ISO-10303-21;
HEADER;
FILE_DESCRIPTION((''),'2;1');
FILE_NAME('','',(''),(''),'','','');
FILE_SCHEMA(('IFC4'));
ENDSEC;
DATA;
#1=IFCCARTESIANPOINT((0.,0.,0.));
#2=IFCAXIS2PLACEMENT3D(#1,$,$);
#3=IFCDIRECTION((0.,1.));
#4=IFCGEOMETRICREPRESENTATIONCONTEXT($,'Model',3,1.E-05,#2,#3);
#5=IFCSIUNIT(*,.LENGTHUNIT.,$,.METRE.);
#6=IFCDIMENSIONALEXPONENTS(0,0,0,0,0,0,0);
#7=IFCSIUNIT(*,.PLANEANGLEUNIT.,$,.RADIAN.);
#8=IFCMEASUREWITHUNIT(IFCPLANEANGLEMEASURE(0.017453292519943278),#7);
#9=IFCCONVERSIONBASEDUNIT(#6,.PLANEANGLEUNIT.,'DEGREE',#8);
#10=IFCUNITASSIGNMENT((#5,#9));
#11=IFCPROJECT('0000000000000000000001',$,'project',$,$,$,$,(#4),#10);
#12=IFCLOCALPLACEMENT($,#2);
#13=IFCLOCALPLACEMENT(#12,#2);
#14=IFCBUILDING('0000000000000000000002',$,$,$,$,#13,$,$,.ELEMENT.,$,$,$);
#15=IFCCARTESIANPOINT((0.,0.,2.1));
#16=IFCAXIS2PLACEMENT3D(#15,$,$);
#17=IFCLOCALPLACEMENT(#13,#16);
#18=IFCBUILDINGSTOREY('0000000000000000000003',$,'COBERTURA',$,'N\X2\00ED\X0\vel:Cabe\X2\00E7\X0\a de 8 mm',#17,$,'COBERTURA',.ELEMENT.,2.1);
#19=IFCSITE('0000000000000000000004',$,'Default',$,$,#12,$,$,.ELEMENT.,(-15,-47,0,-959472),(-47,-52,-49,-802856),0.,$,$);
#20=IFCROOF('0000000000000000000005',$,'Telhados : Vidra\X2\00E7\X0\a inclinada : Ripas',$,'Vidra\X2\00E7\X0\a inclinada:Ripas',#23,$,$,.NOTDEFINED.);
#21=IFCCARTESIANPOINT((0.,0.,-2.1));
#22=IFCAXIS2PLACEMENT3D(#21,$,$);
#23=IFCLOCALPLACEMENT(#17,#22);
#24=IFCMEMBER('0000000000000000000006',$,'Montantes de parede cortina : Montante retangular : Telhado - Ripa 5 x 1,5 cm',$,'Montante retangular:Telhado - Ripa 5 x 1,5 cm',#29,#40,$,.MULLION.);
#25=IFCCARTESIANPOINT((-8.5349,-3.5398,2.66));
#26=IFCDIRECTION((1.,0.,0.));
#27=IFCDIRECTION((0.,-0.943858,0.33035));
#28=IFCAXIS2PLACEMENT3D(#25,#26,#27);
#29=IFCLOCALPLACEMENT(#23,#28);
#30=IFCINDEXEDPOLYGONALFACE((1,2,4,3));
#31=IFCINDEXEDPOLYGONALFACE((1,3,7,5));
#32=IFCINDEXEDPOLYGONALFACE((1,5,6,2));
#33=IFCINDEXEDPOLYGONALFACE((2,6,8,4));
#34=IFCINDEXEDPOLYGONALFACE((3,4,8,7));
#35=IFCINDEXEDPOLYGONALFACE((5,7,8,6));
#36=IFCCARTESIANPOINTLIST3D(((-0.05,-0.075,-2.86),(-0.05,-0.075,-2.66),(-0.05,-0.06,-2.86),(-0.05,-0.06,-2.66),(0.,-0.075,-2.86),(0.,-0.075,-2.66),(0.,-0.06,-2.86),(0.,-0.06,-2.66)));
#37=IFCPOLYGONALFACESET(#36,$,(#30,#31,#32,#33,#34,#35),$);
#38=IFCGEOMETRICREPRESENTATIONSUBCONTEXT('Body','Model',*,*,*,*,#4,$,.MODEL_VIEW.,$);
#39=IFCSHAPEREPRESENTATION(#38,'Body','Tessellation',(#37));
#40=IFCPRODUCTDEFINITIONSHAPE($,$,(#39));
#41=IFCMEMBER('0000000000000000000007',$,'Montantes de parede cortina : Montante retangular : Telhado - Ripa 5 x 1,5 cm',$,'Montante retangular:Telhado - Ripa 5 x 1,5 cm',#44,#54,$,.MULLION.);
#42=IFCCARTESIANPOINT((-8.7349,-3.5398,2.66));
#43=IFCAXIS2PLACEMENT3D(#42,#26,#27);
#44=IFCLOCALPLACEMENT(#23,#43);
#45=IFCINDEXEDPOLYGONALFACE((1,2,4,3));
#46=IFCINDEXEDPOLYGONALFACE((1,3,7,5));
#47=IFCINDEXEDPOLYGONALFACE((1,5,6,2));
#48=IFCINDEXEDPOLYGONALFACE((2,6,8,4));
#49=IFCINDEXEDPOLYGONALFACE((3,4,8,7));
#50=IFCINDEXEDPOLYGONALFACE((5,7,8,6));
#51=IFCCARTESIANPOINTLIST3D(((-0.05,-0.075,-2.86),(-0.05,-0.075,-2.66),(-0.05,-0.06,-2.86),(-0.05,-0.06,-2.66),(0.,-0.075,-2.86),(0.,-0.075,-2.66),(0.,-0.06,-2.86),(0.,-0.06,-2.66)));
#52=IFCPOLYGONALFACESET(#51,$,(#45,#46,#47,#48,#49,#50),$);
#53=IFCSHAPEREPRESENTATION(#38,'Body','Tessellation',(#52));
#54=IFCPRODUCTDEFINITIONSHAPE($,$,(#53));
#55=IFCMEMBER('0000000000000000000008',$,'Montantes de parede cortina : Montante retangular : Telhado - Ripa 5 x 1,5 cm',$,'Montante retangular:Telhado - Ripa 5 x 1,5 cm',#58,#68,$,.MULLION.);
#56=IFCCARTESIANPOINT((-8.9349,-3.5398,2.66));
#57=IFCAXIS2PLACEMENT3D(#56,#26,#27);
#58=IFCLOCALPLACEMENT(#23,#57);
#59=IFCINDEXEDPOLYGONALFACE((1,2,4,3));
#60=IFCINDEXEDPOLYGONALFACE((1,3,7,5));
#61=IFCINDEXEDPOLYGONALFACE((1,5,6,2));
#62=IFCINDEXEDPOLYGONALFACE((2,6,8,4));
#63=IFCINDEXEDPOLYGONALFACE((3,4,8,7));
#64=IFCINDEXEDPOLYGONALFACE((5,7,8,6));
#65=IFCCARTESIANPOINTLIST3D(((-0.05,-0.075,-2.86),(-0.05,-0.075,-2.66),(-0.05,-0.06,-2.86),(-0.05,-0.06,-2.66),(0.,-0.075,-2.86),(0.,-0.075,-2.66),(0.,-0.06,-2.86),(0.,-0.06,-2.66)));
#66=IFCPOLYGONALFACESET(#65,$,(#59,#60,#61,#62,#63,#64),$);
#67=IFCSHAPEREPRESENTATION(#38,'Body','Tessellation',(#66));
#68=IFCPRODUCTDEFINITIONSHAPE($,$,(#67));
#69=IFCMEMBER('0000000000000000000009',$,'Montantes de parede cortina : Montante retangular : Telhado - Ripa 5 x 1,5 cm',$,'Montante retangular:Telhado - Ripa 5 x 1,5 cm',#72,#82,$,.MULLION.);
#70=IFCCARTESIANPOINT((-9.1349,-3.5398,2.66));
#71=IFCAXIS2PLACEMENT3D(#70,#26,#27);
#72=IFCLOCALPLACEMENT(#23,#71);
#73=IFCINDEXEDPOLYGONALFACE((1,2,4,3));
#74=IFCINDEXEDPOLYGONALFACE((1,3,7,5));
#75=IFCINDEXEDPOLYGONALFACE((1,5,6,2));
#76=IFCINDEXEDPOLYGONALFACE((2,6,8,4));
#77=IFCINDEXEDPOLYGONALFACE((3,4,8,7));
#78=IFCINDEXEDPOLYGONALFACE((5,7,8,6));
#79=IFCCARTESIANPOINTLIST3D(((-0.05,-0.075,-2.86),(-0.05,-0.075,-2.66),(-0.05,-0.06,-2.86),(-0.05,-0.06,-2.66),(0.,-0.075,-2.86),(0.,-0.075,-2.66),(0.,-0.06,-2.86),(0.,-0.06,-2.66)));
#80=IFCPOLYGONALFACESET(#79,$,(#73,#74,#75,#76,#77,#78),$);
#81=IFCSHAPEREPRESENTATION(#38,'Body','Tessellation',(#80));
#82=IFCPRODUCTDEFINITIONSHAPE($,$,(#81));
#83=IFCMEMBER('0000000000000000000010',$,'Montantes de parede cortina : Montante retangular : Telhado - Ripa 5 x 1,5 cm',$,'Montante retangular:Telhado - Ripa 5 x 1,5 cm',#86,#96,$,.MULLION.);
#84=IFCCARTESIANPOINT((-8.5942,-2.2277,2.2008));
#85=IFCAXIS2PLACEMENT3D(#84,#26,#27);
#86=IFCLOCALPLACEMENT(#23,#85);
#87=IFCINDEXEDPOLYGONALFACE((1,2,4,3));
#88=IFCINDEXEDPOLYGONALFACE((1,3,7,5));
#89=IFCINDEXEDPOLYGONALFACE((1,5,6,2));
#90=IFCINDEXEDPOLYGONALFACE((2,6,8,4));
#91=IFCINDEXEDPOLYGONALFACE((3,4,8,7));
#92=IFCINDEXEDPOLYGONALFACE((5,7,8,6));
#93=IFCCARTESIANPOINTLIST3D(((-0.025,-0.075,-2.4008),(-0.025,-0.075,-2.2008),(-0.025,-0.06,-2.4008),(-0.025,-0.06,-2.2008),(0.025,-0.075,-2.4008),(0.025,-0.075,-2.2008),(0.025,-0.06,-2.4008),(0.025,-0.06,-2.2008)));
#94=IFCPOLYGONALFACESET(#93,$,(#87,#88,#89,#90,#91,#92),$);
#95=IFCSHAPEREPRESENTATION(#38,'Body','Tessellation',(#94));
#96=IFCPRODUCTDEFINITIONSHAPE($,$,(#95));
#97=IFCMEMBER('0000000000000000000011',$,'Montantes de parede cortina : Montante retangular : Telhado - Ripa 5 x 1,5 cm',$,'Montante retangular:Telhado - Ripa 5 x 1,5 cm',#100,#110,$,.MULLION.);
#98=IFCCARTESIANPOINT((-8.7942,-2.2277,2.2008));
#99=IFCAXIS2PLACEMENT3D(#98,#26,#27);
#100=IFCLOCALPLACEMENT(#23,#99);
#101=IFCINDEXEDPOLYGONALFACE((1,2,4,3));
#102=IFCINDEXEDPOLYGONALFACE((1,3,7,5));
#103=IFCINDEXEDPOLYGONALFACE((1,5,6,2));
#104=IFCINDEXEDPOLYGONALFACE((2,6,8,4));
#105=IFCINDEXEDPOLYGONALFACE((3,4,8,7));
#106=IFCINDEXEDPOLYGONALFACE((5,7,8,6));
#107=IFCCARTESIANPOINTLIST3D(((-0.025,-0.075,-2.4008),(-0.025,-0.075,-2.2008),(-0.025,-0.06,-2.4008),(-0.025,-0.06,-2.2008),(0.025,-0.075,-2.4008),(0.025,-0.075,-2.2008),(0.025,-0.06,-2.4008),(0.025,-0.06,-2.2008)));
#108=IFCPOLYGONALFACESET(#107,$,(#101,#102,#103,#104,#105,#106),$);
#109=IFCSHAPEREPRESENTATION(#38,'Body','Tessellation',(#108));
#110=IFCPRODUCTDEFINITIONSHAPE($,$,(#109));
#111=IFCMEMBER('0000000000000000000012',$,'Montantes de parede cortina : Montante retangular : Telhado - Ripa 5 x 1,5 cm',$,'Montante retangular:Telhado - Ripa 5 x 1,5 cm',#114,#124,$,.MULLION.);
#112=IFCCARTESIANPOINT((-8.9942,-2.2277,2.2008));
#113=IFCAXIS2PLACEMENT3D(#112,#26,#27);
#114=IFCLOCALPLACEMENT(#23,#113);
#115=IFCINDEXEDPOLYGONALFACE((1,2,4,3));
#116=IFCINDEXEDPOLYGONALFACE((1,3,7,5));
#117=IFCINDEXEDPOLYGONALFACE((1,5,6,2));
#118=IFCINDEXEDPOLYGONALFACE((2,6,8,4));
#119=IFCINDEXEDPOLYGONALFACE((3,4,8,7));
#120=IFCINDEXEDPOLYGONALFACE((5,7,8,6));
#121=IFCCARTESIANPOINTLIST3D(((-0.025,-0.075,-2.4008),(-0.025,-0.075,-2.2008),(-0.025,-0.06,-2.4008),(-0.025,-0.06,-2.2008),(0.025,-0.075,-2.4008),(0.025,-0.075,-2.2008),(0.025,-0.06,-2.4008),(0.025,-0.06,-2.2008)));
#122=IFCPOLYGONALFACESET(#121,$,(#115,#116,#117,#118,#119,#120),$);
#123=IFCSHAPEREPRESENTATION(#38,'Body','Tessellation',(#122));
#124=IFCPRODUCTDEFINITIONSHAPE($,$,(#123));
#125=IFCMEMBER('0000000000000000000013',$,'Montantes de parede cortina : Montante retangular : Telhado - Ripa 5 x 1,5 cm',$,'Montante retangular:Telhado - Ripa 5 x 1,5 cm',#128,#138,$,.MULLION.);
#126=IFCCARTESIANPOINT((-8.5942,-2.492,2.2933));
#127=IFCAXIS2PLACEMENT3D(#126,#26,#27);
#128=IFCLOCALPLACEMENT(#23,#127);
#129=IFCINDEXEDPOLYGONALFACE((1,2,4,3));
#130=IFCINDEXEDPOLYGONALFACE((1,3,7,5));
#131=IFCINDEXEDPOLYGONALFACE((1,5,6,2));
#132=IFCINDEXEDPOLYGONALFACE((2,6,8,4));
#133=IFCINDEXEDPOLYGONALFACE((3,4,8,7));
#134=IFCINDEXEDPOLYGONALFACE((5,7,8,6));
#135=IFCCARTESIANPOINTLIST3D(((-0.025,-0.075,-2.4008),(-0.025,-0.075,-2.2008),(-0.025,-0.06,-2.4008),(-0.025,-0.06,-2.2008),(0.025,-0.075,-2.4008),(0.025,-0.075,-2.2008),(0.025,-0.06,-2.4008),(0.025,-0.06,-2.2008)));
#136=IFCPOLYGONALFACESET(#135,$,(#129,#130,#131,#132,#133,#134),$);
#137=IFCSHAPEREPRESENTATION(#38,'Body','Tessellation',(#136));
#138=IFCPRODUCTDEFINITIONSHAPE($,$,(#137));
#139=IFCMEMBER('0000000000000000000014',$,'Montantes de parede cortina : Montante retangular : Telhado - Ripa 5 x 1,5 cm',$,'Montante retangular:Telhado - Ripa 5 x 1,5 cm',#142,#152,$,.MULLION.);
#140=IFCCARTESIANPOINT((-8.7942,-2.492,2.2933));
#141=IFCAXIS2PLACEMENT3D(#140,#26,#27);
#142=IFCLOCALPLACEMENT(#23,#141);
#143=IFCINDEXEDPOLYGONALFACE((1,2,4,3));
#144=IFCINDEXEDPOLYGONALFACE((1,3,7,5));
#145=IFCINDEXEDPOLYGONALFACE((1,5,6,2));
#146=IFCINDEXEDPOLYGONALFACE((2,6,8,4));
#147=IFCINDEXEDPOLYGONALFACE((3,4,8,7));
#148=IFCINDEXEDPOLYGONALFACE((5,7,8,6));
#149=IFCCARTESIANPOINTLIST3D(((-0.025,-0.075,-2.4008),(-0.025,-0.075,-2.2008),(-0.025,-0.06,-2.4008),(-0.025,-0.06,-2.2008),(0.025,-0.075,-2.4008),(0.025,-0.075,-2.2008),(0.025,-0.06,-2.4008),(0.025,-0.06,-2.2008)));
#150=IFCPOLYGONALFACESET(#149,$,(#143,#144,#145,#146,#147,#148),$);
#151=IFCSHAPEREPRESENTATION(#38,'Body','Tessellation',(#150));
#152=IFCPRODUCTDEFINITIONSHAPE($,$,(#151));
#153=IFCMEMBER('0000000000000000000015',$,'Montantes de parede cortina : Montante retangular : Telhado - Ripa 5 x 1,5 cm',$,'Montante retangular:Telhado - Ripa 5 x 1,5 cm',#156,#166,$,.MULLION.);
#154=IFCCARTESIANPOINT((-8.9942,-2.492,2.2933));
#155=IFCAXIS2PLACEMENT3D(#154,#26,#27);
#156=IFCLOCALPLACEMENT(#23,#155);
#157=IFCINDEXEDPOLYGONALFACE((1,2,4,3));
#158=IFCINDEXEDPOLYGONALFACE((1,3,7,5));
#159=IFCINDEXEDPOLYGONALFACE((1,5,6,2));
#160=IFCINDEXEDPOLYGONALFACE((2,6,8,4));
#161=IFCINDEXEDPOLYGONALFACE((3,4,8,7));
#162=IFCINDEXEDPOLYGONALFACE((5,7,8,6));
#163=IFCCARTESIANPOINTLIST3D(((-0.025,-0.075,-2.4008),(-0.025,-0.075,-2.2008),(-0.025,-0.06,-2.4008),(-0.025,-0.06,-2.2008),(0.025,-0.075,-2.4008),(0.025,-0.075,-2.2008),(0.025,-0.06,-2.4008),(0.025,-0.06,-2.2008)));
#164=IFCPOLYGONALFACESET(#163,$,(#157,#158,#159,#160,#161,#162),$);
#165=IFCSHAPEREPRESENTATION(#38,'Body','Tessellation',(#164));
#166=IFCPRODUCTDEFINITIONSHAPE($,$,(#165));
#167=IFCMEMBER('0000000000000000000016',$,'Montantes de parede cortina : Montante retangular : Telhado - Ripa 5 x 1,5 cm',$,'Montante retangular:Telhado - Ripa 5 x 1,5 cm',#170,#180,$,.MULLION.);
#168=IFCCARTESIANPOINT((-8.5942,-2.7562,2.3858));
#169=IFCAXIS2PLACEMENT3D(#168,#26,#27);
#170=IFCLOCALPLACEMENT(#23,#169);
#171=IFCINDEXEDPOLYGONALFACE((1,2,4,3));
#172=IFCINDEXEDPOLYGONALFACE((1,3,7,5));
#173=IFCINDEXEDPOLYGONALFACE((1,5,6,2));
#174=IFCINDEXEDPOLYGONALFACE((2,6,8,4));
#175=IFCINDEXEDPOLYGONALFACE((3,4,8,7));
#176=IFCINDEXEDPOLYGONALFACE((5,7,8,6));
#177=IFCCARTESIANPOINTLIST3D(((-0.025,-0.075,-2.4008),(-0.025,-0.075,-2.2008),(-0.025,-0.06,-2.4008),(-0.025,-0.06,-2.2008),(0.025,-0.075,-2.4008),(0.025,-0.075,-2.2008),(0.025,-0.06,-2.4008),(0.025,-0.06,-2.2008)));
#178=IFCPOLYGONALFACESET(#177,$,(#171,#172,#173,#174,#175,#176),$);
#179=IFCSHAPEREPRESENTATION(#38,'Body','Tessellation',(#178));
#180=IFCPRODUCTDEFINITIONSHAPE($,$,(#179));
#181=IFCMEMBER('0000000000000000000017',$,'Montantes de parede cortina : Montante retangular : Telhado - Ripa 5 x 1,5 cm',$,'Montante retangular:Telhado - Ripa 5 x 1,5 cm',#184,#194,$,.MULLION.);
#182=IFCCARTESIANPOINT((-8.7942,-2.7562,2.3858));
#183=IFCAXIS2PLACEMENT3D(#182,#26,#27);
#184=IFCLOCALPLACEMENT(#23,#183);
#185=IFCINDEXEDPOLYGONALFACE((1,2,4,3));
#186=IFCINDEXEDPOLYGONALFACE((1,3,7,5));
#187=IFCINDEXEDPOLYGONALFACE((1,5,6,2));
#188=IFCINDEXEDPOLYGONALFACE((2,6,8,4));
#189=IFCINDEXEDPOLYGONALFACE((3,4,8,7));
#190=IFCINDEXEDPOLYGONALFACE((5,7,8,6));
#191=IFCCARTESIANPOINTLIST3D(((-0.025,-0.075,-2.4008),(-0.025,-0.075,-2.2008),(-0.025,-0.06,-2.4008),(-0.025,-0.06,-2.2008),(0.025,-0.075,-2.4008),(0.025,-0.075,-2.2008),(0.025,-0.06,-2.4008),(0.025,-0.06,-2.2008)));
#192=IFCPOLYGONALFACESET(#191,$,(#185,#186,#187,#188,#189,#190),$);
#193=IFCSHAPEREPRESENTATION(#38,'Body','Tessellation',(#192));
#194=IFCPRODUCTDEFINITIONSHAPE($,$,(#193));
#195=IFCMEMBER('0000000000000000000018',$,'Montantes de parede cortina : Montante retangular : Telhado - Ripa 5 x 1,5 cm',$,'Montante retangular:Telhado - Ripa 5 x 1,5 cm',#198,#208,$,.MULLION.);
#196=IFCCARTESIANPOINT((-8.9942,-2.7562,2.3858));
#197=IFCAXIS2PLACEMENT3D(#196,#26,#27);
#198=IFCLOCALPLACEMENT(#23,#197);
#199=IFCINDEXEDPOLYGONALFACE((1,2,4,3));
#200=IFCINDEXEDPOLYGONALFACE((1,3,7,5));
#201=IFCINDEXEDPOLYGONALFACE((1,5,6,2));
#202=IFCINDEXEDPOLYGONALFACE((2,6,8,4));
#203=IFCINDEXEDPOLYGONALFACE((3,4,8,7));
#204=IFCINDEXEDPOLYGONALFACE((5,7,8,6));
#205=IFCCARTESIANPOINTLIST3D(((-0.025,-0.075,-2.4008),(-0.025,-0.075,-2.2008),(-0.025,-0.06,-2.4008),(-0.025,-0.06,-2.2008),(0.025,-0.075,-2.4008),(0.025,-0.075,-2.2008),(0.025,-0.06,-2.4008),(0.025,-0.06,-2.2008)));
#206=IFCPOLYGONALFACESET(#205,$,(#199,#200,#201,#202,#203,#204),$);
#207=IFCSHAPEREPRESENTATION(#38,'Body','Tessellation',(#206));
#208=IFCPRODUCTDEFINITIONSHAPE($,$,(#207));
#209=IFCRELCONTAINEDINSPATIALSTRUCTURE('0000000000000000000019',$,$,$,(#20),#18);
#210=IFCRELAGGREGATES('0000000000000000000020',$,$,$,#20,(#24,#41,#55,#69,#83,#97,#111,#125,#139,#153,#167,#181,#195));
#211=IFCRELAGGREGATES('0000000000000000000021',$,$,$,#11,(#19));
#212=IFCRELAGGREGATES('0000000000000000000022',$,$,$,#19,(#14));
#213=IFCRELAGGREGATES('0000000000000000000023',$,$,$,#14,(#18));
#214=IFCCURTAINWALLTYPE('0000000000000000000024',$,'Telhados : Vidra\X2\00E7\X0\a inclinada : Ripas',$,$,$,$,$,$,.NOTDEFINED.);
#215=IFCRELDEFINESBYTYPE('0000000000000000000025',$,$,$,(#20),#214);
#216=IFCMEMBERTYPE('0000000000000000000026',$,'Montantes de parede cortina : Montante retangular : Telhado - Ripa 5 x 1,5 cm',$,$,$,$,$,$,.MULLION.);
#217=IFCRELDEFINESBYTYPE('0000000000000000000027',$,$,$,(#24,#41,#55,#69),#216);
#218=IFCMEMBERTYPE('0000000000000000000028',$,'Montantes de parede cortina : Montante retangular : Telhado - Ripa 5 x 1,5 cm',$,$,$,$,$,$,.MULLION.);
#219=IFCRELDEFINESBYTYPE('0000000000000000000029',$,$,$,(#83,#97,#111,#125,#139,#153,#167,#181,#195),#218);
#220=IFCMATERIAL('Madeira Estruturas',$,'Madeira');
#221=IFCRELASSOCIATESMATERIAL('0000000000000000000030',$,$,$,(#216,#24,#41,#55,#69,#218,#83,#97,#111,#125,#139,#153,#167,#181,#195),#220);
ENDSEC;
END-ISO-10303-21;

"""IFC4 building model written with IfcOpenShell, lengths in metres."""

from ifc_helpers import new_model, entity, si_unit, converted_unit, direction, frame, origin, place, context, subcontext, project, spatial, indexed_curve, outline, extrude, source, transform, mapped, material, type_object, type_shapes, element, aggregate, save


model = new_model("IFC4")

# Units and contexts
model_context = context("Model", 3, precision=1e-05, world=origin(), true_north=direction((0.0, 1.0)))
body_context = subcontext(model_context, "Body", "Model", "MODEL_VIEW")
ifc_project = project(units=[si_unit("LENGTHUNIT", "METRE"), converted_unit("PLANEANGLEUNIT", "DEGREE", entity("IfcPlaneAngleMeasure", 0.017453292519943278), si_unit("PLANEANGLEUNIT", "RADIAN"), dimensions=[0, 0, 0, 0, 0, 0, 0])], contexts=[model_context])

# Site, building, storey
site_placement = place(None, origin())
site = spatial("IfcSite", under=ifc_project, at=site_placement, Name="Default", CompositionType="ELEMENT", RefLatitude=(-15, -47, 0, -959472), RefLongitude=(-47, -52, -49, -802856), RefElevation=0.0)
building_placement = place(site_placement, origin())
building = spatial("IfcBuilding", under=site, at=building_placement, CompositionType="ELEMENT")
storey_placement = place(building_placement, frame((0.0, 0.0, 2.1)))
storey = spatial("IfcBuildingStorey", under=building, at=storey_placement, Name="COBERTURA", ObjectType="Nível:Cabeça de 8 mm", LongName="COBERTURA", CompositionType="ELEMENT", Elevation=2.1)

# Roof, members
curtain_wall_type = type_object("IfcCurtainWallType", Name="Telhados : Vidraça inclinada : Ripas", PredefinedType="NOTDEFINED")
roof_placement = place(storey_placement, frame((0.0, 0.0, -2.1)))
roof = element("IfcRoof", 1, at=roof_placement, inside=storey, type_object=curtain_wall_type, Name="Telhados : Vidraça inclinada : Ripas", ObjectType="Vidraça inclinada:Ripas", PredefinedType="NOTDEFINED")
ifc_material = material(Name="Madeira Estruturas", Category="Madeira")
member_type_1 = type_object("IfcMemberType", Name="Montantes de parede cortina : Montante retangular : Telhado - Ripa 5 x 1,5 cm", PredefinedType="MULLION", material=ifc_material)
shared_shape_1 = source(origin(), body_context, "Body", "SweptSolid", [
    extrude(outline(indexed_curve([(-0.025, -0.0075), (0.025, -0.0075), (0.025, 0.0075), (-0.025, 0.0075), (-0.025, -0.0075)], self_intersect=False)), frame((-0.025, -0.0675, -2.86), z_axis=(0.0, 0.0, 1.0), x_axis=(-1.0, 0.0, 0.0)), (0.0, 0.0, 1.0), 0.2),
])
type_shapes(member_type_1, [shared_shape_1])
member_1_placement = place(roof_placement, frame((-8.5349, -3.5398, 2.66), z_axis=(1.0, 0.0, 0.0), x_axis=(0.0, -0.943858, 0.33035)))
member_1 = element("IfcMember", 2, at=member_1_placement, type_object=member_type_1, material=ifc_material, Name="Montantes de parede cortina : Montante retangular : Telhado - Ripa 5 x 1,5 cm", ObjectType="Montante retangular:Telhado - Ripa 5 x 1,5 cm", PredefinedType="MULLION", context=body_context, shape_type="MappedRepresentation", body=[
    mapped(shared_shape_1, transform((0.0, 0.0, 0.0), scale=1.0)),
])
member_2_placement = place(roof_placement, frame((-8.7349, -3.5398, 2.66), z_axis=(1.0, 0.0, 0.0), x_axis=(0.0, -0.943858, 0.33035)))
member_2 = element("IfcMember", 3, at=member_2_placement, type_object=member_type_1, material=ifc_material, Name="Montantes de parede cortina : Montante retangular : Telhado - Ripa 5 x 1,5 cm", ObjectType="Montante retangular:Telhado - Ripa 5 x 1,5 cm", PredefinedType="MULLION", context=body_context, shape_type="MappedRepresentation", body=[
    mapped(shared_shape_1, transform((0.0, 0.0, 0.0), scale=1.0)),
])
member_3_placement = place(roof_placement, frame((-8.9349, -3.5398, 2.66), z_axis=(1.0, 0.0, 0.0), x_axis=(0.0, -0.943858, 0.33035)))
member_3 = element("IfcMember", 4, at=member_3_placement, type_object=member_type_1, material=ifc_material, Name="Montantes de parede cortina : Montante retangular : Telhado - Ripa 5 x 1,5 cm", ObjectType="Montante retangular:Telhado - Ripa 5 x 1,5 cm", PredefinedType="MULLION", context=body_context, shape_type="MappedRepresentation", body=[
    mapped(shared_shape_1, transform((0.0, 0.0, 0.0), scale=1.0)),
])
member_4_placement = place(roof_placement, frame((-9.1349, -3.5398, 2.66), z_axis=(1.0, 0.0, 0.0), x_axis=(0.0, -0.943858, 0.33035)))
member_4 = element("IfcMember", 5, at=member_4_placement, type_object=member_type_1, material=ifc_material, Name="Montantes de parede cortina : Montante retangular : Telhado - Ripa 5 x 1,5 cm", ObjectType="Montante retangular:Telhado - Ripa 5 x 1,5 cm", PredefinedType="MULLION", context=body_context, shape_type="MappedRepresentation", body=[
    mapped(shared_shape_1, transform((0.0, 0.0, 0.0), scale=1.0)),
])
member_type_2 = type_object("IfcMemberType", Name="Montantes de parede cortina : Montante retangular : Telhado - Ripa 5 x 1,5 cm", PredefinedType="MULLION", material=ifc_material)
shared_shape_2 = source(origin(), body_context, "Body", "SweptSolid", [
    extrude(outline(indexed_curve([(-0.025, -0.0075), (0.025, -0.0075), (0.025, 0.0075), (-0.025, 0.0075), (-0.025, -0.0075)], self_intersect=False)), frame((0.0, -0.0675, -2.4008), z_axis=(0.0, 0.0, 1.0), x_axis=(-1.0, 0.0, 0.0)), (0.0, 0.0, 1.0), 0.2),
])
type_shapes(member_type_2, [shared_shape_2])
member_5_placement = place(roof_placement, frame((-8.5942, -2.2277, 2.2008), z_axis=(1.0, 0.0, 0.0), x_axis=(0.0, -0.943858, 0.33035)))
member_5 = element("IfcMember", 6, at=member_5_placement, type_object=member_type_2, material=ifc_material, Name="Montantes de parede cortina : Montante retangular : Telhado - Ripa 5 x 1,5 cm", ObjectType="Montante retangular:Telhado - Ripa 5 x 1,5 cm", PredefinedType="MULLION", context=body_context, shape_type="MappedRepresentation", body=[
    mapped(shared_shape_2, transform((0.0, 0.0, 0.0), scale=1.0)),
])
member_6_placement = place(roof_placement, frame((-8.7942, -2.2277, 2.2008), z_axis=(1.0, 0.0, 0.0), x_axis=(0.0, -0.943858, 0.33035)))
member_6 = element("IfcMember", 7, at=member_6_placement, type_object=member_type_2, material=ifc_material, Name="Montantes de parede cortina : Montante retangular : Telhado - Ripa 5 x 1,5 cm", ObjectType="Montante retangular:Telhado - Ripa 5 x 1,5 cm", PredefinedType="MULLION", context=body_context, shape_type="MappedRepresentation", body=[
    mapped(shared_shape_2, transform((0.0, 0.0, 0.0), scale=1.0)),
])
member_7_placement = place(roof_placement, frame((-8.9942, -2.2277, 2.2008), z_axis=(1.0, 0.0, 0.0), x_axis=(0.0, -0.943858, 0.33035)))
member_7 = element("IfcMember", 8, at=member_7_placement, type_object=member_type_2, material=ifc_material, Name="Montantes de parede cortina : Montante retangular : Telhado - Ripa 5 x 1,5 cm", ObjectType="Montante retangular:Telhado - Ripa 5 x 1,5 cm", PredefinedType="MULLION", context=body_context, shape_type="MappedRepresentation", body=[
    mapped(shared_shape_2, transform((0.0, 0.0, 0.0), scale=1.0)),
])
member_8_placement = place(roof_placement, frame((-8.5942, -2.492, 2.2933), z_axis=(1.0, 0.0, 0.0), x_axis=(0.0, -0.943858, 0.33035)))
member_8 = element("IfcMember", 9, at=member_8_placement, type_object=member_type_2, material=ifc_material, Name="Montantes de parede cortina : Montante retangular : Telhado - Ripa 5 x 1,5 cm", ObjectType="Montante retangular:Telhado - Ripa 5 x 1,5 cm", PredefinedType="MULLION", context=body_context, shape_type="MappedRepresentation", body=[
    mapped(shared_shape_2, transform((0.0, 0.0, 0.0), scale=1.0)),
])
member_9_placement = place(roof_placement, frame((-8.7942, -2.492, 2.2933), z_axis=(1.0, 0.0, 0.0), x_axis=(0.0, -0.943858, 0.33035)))
member_9 = element("IfcMember", 10, at=member_9_placement, type_object=member_type_2, material=ifc_material, Name="Montantes de parede cortina : Montante retangular : Telhado - Ripa 5 x 1,5 cm", ObjectType="Montante retangular:Telhado - Ripa 5 x 1,5 cm", PredefinedType="MULLION", context=body_context, shape_type="MappedRepresentation", body=[
    mapped(shared_shape_2, transform((0.0, 0.0, 0.0), scale=1.0)),
])
member_10_placement = place(roof_placement, frame((-8.9942, -2.492, 2.2933), z_axis=(1.0, 0.0, 0.0), x_axis=(0.0, -0.943858, 0.33035)))
member_10 = element("IfcMember", 11, at=member_10_placement, type_object=member_type_2, material=ifc_material, Name="Montantes de parede cortina : Montante retangular : Telhado - Ripa 5 x 1,5 cm", ObjectType="Montante retangular:Telhado - Ripa 5 x 1,5 cm", PredefinedType="MULLION", context=body_context, shape_type="MappedRepresentation", body=[
    mapped(shared_shape_2, transform((0.0, 0.0, 0.0), scale=1.0)),
])
member_11_placement = place(roof_placement, frame((-8.5942, -2.7562, 2.3858), z_axis=(1.0, 0.0, 0.0), x_axis=(0.0, -0.943858, 0.33035)))
member_11 = element("IfcMember", 12, at=member_11_placement, type_object=member_type_2, material=ifc_material, Name="Montantes de parede cortina : Montante retangular : Telhado - Ripa 5 x 1,5 cm", ObjectType="Montante retangular:Telhado - Ripa 5 x 1,5 cm", PredefinedType="MULLION", context=body_context, shape_type="MappedRepresentation", body=[
    mapped(shared_shape_2, transform((0.0, 0.0, 0.0), scale=1.0)),
])
member_12_placement = place(roof_placement, frame((-8.7942, -2.7562, 2.3858), z_axis=(1.0, 0.0, 0.0), x_axis=(0.0, -0.943858, 0.33035)))
member_12 = element("IfcMember", 13, at=member_12_placement, type_object=member_type_2, material=ifc_material, Name="Montantes de parede cortina : Montante retangular : Telhado - Ripa 5 x 1,5 cm", ObjectType="Montante retangular:Telhado - Ripa 5 x 1,5 cm", PredefinedType="MULLION", context=body_context, shape_type="MappedRepresentation", body=[
    mapped(shared_shape_2, transform((0.0, 0.0, 0.0), scale=1.0)),
])
member_13_placement = place(roof_placement, frame((-8.9942, -2.7562, 2.3858), z_axis=(1.0, 0.0, 0.0), x_axis=(0.0, -0.943858, 0.33035)))
member_13 = element("IfcMember", 14, at=member_13_placement, type_object=member_type_2, material=ifc_material, Name="Montantes de parede cortina : Montante retangular : Telhado - Ripa 5 x 1,5 cm", ObjectType="Montante retangular:Telhado - Ripa 5 x 1,5 cm", PredefinedType="MULLION", context=body_context, shape_type="MappedRepresentation", body=[
    mapped(shared_shape_2, transform((0.0, 0.0, 0.0), scale=1.0)),
])
aggregate(roof, [member_1, member_2, member_3, member_4, member_5, member_6, member_7, member_8, member_9, member_10, member_11, member_12, member_13])

save(model, "model.ifc")
